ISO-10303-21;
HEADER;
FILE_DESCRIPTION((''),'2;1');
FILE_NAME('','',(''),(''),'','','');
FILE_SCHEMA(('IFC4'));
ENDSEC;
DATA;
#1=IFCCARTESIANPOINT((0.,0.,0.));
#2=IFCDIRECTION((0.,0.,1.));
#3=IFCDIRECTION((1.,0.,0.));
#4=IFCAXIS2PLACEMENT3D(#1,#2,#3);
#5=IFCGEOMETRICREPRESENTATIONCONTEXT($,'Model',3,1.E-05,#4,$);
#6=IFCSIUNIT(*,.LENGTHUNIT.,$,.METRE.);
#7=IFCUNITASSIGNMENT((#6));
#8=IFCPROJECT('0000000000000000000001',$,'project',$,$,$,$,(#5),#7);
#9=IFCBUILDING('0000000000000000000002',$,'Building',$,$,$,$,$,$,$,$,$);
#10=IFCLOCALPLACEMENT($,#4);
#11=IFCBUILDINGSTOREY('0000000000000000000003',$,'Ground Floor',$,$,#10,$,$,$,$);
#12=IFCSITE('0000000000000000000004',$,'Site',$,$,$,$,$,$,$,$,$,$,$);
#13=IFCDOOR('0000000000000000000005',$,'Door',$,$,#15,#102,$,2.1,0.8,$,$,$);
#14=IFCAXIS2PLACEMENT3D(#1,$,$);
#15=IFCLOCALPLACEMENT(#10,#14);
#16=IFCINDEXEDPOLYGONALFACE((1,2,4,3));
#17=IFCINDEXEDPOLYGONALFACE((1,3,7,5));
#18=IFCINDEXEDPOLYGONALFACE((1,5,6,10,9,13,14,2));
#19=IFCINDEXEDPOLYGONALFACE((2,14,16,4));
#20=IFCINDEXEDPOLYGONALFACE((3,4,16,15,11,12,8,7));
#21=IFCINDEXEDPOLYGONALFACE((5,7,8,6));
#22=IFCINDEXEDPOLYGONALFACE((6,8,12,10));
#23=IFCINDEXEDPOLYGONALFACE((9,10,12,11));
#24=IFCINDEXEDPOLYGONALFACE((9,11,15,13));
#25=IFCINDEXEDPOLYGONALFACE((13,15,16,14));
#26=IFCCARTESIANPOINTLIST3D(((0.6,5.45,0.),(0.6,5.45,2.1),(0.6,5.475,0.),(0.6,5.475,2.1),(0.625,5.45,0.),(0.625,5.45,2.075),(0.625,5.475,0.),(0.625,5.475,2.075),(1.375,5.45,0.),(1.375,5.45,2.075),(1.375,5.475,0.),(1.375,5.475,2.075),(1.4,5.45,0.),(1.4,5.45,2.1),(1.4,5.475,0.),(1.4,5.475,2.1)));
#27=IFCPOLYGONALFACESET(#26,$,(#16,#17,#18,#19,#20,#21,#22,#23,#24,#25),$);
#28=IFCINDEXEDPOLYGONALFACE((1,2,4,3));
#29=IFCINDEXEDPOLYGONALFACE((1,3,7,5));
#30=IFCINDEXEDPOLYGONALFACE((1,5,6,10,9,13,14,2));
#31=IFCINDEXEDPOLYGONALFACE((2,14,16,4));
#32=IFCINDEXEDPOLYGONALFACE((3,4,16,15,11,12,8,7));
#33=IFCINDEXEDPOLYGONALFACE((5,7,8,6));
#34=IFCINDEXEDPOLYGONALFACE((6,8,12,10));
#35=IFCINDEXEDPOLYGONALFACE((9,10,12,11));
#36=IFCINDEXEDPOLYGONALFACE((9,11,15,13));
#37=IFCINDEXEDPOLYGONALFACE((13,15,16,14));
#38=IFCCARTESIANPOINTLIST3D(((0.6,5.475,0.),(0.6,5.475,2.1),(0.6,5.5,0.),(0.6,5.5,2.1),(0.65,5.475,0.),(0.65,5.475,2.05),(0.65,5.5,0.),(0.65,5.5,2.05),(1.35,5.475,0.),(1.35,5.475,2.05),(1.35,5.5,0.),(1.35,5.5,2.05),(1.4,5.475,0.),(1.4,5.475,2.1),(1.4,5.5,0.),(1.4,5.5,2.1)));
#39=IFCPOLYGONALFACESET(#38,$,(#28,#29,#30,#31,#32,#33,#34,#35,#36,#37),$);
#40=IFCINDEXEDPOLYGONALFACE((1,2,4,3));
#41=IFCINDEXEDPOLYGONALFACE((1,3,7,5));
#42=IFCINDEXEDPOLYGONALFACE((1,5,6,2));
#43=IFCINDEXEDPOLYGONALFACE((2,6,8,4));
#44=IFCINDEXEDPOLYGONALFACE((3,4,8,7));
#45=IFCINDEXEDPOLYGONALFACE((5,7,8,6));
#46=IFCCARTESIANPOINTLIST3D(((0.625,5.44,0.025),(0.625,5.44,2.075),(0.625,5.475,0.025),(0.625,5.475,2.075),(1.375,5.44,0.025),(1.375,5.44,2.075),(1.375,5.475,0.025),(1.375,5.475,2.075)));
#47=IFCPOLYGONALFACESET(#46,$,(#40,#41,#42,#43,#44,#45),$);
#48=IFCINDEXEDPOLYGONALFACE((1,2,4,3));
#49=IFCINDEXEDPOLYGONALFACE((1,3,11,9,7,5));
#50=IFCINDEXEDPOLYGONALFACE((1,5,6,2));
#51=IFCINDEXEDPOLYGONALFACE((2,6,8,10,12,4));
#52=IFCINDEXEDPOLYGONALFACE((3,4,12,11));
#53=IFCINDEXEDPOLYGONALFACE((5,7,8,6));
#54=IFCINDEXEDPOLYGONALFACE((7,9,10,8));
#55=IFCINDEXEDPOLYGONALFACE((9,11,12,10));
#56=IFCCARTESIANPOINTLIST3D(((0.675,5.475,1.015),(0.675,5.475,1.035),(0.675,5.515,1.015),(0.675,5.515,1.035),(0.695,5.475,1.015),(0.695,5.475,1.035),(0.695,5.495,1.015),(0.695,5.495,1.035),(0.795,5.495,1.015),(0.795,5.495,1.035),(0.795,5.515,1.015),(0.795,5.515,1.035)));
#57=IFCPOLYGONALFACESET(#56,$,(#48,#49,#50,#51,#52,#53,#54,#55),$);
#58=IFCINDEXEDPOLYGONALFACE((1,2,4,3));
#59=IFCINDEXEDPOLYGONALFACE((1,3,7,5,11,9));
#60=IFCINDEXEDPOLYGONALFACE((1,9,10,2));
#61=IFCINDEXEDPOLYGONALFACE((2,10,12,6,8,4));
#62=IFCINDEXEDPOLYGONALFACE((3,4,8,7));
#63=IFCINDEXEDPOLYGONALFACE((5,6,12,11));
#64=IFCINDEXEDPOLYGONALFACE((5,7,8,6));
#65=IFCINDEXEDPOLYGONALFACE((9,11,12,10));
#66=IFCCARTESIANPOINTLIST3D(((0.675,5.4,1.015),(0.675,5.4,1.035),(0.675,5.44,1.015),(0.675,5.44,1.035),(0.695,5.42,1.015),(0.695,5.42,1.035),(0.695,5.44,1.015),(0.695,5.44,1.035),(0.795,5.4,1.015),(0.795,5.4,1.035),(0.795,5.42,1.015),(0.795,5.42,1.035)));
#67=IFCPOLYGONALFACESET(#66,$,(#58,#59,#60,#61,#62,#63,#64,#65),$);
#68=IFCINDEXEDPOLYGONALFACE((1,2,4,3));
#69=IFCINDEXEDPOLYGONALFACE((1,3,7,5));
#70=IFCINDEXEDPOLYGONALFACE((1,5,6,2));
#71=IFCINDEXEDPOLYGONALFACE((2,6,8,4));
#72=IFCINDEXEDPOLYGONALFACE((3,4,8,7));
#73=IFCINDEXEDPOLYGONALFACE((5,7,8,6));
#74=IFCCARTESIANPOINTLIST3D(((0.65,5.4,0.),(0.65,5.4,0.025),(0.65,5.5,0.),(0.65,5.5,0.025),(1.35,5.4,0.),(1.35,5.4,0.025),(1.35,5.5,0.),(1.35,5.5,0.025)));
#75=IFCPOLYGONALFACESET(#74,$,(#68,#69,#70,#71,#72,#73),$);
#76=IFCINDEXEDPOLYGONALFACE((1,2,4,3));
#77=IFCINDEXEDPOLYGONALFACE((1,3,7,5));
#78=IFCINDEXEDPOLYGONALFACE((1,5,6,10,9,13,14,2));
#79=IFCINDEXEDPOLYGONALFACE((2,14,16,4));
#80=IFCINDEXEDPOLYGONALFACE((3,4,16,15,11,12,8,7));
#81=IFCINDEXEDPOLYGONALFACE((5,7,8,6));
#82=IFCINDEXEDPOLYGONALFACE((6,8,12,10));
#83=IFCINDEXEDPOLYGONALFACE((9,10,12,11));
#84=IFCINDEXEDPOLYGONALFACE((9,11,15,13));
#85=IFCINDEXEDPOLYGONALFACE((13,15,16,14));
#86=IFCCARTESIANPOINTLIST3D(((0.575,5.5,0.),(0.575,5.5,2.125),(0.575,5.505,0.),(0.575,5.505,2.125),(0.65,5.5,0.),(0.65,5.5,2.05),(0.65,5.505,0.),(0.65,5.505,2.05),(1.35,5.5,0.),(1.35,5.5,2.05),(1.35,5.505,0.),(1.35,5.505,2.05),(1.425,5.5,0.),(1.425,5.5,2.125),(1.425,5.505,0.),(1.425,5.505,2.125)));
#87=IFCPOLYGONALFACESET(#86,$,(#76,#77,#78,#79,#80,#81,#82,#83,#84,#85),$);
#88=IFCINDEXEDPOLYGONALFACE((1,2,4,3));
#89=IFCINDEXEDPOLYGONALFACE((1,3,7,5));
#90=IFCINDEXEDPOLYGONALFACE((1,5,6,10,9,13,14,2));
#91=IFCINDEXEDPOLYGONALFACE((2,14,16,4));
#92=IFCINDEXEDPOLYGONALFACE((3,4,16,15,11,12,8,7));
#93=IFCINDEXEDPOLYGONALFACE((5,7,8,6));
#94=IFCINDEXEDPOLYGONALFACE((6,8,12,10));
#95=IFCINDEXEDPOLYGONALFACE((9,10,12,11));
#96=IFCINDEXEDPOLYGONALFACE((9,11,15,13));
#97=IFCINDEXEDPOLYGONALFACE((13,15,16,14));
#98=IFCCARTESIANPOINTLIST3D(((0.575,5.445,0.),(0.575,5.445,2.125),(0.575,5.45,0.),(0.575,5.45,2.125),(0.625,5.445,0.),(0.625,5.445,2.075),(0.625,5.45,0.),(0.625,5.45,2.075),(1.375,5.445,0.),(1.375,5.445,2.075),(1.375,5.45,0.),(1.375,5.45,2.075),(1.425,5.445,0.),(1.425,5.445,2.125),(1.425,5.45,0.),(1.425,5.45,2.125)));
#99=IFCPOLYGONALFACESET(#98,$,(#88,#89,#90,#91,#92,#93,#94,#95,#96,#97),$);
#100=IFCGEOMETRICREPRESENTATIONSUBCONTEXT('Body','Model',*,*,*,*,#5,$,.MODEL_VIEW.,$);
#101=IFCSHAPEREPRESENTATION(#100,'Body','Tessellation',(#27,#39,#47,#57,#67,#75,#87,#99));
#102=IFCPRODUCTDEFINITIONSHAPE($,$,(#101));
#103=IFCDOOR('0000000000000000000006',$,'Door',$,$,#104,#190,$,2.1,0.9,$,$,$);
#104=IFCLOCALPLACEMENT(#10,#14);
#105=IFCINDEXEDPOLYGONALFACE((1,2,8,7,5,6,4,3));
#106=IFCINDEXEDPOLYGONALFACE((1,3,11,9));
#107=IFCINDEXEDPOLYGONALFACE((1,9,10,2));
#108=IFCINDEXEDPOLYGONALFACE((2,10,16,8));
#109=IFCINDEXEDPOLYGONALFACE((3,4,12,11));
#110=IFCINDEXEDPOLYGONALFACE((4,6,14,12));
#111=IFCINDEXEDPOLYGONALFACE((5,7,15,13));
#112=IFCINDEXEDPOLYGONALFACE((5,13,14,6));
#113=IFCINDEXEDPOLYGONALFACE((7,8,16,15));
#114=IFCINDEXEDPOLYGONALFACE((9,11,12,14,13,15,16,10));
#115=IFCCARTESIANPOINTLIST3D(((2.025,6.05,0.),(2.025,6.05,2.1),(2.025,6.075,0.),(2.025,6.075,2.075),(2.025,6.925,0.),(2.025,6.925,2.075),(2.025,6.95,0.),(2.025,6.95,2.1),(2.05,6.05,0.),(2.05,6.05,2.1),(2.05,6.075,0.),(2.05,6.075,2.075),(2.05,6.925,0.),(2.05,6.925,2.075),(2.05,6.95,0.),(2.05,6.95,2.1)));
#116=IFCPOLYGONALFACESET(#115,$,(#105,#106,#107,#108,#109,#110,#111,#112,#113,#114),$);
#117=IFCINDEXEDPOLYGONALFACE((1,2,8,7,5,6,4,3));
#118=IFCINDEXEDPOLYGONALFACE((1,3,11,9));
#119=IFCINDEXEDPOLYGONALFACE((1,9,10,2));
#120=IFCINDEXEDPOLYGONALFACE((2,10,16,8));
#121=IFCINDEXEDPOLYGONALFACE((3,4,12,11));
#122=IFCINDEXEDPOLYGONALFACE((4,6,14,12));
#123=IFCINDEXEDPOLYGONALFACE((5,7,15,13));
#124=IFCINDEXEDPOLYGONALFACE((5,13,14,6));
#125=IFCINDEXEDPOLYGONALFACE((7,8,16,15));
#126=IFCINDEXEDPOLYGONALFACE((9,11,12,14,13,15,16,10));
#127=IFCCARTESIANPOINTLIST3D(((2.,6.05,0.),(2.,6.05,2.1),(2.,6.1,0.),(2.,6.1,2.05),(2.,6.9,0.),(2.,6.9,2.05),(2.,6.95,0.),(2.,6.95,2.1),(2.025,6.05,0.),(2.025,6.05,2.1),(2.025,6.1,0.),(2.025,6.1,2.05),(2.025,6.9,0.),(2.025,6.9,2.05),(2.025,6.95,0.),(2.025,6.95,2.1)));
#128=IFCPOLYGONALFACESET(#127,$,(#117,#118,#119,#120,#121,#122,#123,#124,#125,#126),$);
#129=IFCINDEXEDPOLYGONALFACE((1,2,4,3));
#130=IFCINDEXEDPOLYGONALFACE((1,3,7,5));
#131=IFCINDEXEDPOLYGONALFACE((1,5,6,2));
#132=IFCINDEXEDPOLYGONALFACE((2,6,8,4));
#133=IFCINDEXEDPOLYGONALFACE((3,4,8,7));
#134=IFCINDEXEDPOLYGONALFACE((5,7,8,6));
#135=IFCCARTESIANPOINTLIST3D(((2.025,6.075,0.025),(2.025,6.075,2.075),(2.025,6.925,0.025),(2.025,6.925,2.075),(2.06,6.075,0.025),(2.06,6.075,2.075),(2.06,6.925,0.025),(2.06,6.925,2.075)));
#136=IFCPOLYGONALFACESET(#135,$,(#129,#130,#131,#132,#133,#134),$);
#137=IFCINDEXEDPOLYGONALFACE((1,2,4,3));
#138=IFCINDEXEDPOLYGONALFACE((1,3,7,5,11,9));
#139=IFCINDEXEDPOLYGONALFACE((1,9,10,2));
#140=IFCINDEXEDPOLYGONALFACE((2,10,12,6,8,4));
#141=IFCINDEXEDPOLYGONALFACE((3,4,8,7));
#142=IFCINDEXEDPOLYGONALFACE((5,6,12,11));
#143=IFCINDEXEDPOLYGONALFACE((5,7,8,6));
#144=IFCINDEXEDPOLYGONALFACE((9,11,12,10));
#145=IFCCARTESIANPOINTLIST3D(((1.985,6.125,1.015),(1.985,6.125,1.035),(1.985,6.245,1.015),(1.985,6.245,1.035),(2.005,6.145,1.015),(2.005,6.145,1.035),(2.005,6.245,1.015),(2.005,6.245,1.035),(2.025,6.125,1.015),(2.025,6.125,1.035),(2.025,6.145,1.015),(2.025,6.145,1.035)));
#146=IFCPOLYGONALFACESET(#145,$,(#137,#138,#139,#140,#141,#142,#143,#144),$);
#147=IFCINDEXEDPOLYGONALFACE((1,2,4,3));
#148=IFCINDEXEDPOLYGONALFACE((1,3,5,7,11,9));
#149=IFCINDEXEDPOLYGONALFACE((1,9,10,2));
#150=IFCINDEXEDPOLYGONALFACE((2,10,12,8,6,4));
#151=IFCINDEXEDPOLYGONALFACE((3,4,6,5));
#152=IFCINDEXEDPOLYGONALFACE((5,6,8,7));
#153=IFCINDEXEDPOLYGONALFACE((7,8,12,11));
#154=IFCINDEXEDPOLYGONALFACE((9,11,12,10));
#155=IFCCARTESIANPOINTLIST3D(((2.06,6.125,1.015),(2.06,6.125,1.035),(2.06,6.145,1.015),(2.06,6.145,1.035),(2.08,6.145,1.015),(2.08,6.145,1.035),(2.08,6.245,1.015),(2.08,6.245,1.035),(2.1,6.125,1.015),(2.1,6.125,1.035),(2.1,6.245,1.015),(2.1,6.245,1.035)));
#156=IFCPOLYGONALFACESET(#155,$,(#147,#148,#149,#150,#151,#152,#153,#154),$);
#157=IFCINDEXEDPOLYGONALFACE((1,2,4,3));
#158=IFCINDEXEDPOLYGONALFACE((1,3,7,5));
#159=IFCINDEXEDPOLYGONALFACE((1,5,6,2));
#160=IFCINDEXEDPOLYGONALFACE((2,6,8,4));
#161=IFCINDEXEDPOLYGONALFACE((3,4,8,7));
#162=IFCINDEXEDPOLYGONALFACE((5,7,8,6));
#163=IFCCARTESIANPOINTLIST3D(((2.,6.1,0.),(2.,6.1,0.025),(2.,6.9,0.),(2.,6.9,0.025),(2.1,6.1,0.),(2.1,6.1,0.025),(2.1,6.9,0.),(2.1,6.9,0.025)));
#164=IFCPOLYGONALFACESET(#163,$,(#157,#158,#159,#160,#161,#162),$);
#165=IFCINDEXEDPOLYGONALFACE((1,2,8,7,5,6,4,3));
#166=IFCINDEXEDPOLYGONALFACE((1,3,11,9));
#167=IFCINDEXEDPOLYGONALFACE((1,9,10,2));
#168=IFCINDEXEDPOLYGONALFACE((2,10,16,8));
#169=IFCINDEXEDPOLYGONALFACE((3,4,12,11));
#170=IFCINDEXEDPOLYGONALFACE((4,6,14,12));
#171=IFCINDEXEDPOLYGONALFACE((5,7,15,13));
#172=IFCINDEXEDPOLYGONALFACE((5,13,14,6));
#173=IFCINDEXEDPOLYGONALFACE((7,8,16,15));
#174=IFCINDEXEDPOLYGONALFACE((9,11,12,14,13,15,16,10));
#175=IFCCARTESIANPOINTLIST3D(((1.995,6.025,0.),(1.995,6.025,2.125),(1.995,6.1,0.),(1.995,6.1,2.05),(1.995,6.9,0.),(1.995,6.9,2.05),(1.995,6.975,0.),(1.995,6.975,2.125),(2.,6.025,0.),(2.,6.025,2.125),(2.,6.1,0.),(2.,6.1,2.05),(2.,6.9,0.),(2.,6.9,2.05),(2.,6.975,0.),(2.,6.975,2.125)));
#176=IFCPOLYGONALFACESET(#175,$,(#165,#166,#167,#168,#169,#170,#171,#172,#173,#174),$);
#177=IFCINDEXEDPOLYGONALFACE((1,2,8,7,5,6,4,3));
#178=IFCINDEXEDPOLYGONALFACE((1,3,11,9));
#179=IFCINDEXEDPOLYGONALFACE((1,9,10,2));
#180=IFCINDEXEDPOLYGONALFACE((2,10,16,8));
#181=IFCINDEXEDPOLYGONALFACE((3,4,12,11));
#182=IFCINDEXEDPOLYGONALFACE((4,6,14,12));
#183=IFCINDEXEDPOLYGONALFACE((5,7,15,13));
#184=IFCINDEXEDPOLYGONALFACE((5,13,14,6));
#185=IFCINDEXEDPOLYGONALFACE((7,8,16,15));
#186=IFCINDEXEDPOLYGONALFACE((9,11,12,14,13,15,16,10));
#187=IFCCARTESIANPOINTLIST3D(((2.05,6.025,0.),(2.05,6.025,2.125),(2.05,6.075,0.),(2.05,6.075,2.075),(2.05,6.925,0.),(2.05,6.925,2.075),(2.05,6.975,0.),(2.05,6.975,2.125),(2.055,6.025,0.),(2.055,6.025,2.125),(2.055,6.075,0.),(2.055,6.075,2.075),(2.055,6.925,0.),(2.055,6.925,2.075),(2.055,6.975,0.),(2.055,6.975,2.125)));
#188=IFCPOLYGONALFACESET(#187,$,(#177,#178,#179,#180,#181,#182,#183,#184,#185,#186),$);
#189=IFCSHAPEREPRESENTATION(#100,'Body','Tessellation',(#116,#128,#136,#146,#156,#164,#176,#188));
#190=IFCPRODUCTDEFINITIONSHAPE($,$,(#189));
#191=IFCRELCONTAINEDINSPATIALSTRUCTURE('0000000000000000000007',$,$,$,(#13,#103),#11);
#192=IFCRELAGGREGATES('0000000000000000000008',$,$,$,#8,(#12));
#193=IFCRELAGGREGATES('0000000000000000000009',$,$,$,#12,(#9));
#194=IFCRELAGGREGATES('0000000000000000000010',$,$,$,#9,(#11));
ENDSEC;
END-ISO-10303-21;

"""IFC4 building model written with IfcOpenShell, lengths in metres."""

from ifc_helpers import new_model, si_unit, frame, origin_with_axes, place, context, subcontext, project, spatial, line, indexed_curve, outline, extrude, element, save


model = new_model("IFC4")

# Units and contexts
model_context = context("Model", 3, precision=1e-05, world=origin_with_axes())
body_context = subcontext(model_context, "Body", "Model", "MODEL_VIEW")
ifc_project = project(units=[si_unit("LENGTHUNIT", "METRE")], contexts=[model_context])

# Site, building, storey
site = spatial("IfcSite", under=ifc_project, Name="Site")
building = spatial("IfcBuilding", under=site, Name="Building")
storey_placement = place(None, origin_with_axes())
storey = spatial("IfcBuildingStorey", under=building, at=storey_placement, Name="Ground Floor")

# Doors
door_1_placement = place(storey_placement, frame((1.4, 5.5, 0.0), z_axis=(0.0, 0.0, 1.0), x_axis=(-1.0, 0.0, 0.0)))
element("IfcDoor", 1, at=door_1_placement, inside=storey, Name="Door", OverallHeight=2.1, OverallWidth=0.8, context=body_context, shape_type="SweptSolid", body=[
    extrude(outline(indexed_curve([(0.0, 0.0), (0.0, 2.1), (0.8, 2.1), (0.8, 0.0), (0.775, 0.0), (0.775, 2.075), (0.025, 2.075), (0.025, 0.0)], segments=[line(1, 2, 3, 4, 5, 6, 7, 8, 1)])), frame((0.0, 0.025, 0.0), z_axis=(0.0, -1.0, 0.0), x_axis=(1.0, 0.0, 0.0)), (0.0, 0.0, -1.0), 0.025),
    extrude(outline(indexed_curve([(0.0, 0.0), (0.0, 2.1), (0.8, 2.1), (0.8, 0.0), (0.75, 0.0), (0.75, 2.05), (0.05, 2.05), (0.05, 0.0)], segments=[line(1, 2, 3, 4, 5, 6, 7, 8, 1)])), frame((0.0, 0.0, 0.0), z_axis=(0.0, -1.0, 0.0), x_axis=(1.0, 0.0, 0.0)), (0.0, 0.0, -1.0), 0.025),
    extrude(outline(indexed_curve([(0.0, 0.0), (0.75, 0.0), (0.75, 0.035), (0.0, 0.035)], segments=[line(1, 2, 3, 4, 1)])), frame((0.025, 0.025, 0.025), z_axis=(0.0, 0.0, 1.0), x_axis=(1.0, 0.0, 0.0)), (0.0, 0.0, 1.0), 2.05),
    extrude(outline(indexed_curve([(0.0, 0.0), (0.0, -0.04), (-0.12, -0.04), (-0.12, -0.02), (-0.02, -0.02), (-0.02, 0.0)], segments=[line(1, 2, 3, 4, 5, 6, 1)])), frame((0.725, 0.025, 1.015), z_axis=(0.0, 0.0, 1.0), x_axis=(1.0, 0.0, 0.0)), (0.0, 0.0, 1.0), 0.02),
    extrude(outline(indexed_curve([(0.0, 0.0), (0.0, 0.04), (-0.12, 0.04), (-0.12, 0.02), (-0.02, 0.02), (-0.02, 0.0)], segments=[line(1, 2, 3, 4, 5, 6, 1)])), frame((0.725, 0.06, 1.015), z_axis=(0.0, 0.0, 1.0), x_axis=(1.0, 0.0, 0.0)), (0.0, 0.0, 1.0), 0.02),
    extrude(outline(indexed_curve([(0.0, 0.0), (0.7, 0.0), (0.7, 0.1), (0.0, 0.1)], segments=[line(1, 2, 3, 4, 1)])), frame((0.05, 0.0, 0.0), z_axis=(0.0, 0.0, 1.0), x_axis=(1.0, 0.0, 0.0)), (0.0, 0.0, 1.0), 0.025),
    extrude(outline(indexed_curve([(0.0, 0.0), (0.0, 2.125), (0.85, 2.125), (0.85, 0.0), (0.775, 0.0), (0.775, 2.05), (0.075, 2.05), (0.075, 0.0)], segments=[line(1, 2, 3, 4, 5, 6, 7, 8, 1)])), frame((-0.025, -0.005, 0.0), z_axis=(0.0, -1.0, 0.0), x_axis=(1.0, 0.0, 0.0)), (0.0, 0.0, -1.0), 0.005),
    extrude(outline(indexed_curve([(0.0, 0.0), (0.0, 2.125), (0.85, 2.125), (0.85, 0.0), (0.8, 0.0), (0.8, 2.075), (0.05, 2.075), (0.05, 0.0)], segments=[line(1, 2, 3, 4, 5, 6, 7, 8, 1)])), frame((-0.025, 0.05, 0.0), z_axis=(0.0, -1.0, 0.0), x_axis=(1.0, 0.0, 0.0)), (0.0, 0.0, -1.0), 0.005),
])
door_2_placement = place(storey_placement, frame((2.0, 6.95, 0.0), z_axis=(0.0, 0.0, 1.0), x_axis=(0.0, -1.0, 0.0)))
element("IfcDoor", 2, at=door_2_placement, inside=storey, Name="Door", OverallHeight=2.1, OverallWidth=0.9, context=body_context, shape_type="SweptSolid", body=[
    extrude(outline(indexed_curve([(0.0, 0.0), (0.0, 2.1), (0.9, 2.1), (0.9, 0.0), (0.875, 0.0), (0.875, 2.075), (0.025, 2.075), (0.025, 0.0)], segments=[line(1, 2, 3, 4, 5, 6, 7, 8, 1)])), frame((0.0, 0.025, 0.0), z_axis=(0.0, -1.0, 0.0), x_axis=(1.0, 0.0, 0.0)), (0.0, 0.0, -1.0), 0.025),
    extrude(outline(indexed_curve([(0.0, 0.0), (0.0, 2.1), (0.9, 2.1), (0.9, 0.0), (0.85, 0.0), (0.85, 2.05), (0.05, 2.05), (0.05, 0.0)], segments=[line(1, 2, 3, 4, 5, 6, 7, 8, 1)])), frame((0.0, 0.0, 0.0), z_axis=(0.0, -1.0, 0.0), x_axis=(1.0, 0.0, 0.0)), (0.0, 0.0, -1.0), 0.025),
    extrude(outline(indexed_curve([(0.0, 0.0), (0.85, 0.0), (0.85, 0.035), (0.0, 0.035)], segments=[line(1, 2, 3, 4, 1)])), frame((0.025, 0.025, 0.025), z_axis=(0.0, 0.0, 1.0), x_axis=(1.0, 0.0, 0.0)), (0.0, 0.0, 1.0), 2.05),
    extrude(outline(indexed_curve([(0.0, 0.0), (0.0, -0.04), (-0.12, -0.04), (-0.12, -0.02), (-0.02, -0.02), (-0.02, 0.0)], segments=[line(1, 2, 3, 4, 5, 6, 1)])), frame((0.825, 0.025, 1.015), z_axis=(0.0, 0.0, 1.0), x_axis=(1.0, 0.0, 0.0)), (0.0, 0.0, 1.0), 0.02),
    extrude(outline(indexed_curve([(0.0, 0.0), (0.0, 0.04), (-0.12, 0.04), (-0.12, 0.02), (-0.02, 0.02), (-0.02, 0.0)], segments=[line(1, 2, 3, 4, 5, 6, 1)])), frame((0.825, 0.06, 1.015), z_axis=(0.0, 0.0, 1.0), x_axis=(1.0, 0.0, 0.0)), (0.0, 0.0, 1.0), 0.02),
    extrude(outline(indexed_curve([(0.0, 0.0), (0.8, 0.0), (0.8, 0.1), (0.0, 0.1)], segments=[line(1, 2, 3, 4, 1)])), frame((0.05, 0.0, 0.0), z_axis=(0.0, 0.0, 1.0), x_axis=(1.0, 0.0, 0.0)), (0.0, 0.0, 1.0), 0.025),
    extrude(outline(indexed_curve([(0.0, 0.0), (0.0, 2.125), (0.95, 2.125), (0.95, 0.0), (0.875, 0.0), (0.875, 2.05), (0.075, 2.05), (0.075, 0.0)], segments=[line(1, 2, 3, 4, 5, 6, 7, 8, 1)])), frame((-0.025, -0.005, 0.0), z_axis=(0.0, -1.0, 0.0), x_axis=(1.0, 0.0, 0.0)), (0.0, 0.0, -1.0), 0.005),
    extrude(outline(indexed_curve([(0.0, 0.0), (0.0, 2.125), (0.95, 2.125), (0.95, 0.0), (0.9, 0.0), (0.9, 2.075), (0.05, 2.075), (0.05, 0.0)], segments=[line(1, 2, 3, 4, 5, 6, 7, 8, 1)])), frame((-0.025, 0.05, 0.0), z_axis=(0.0, -1.0, 0.0), x_axis=(1.0, 0.0, 0.0)), (0.0, 0.0, -1.0), 0.005),
])

save(model, "model.ifc")
